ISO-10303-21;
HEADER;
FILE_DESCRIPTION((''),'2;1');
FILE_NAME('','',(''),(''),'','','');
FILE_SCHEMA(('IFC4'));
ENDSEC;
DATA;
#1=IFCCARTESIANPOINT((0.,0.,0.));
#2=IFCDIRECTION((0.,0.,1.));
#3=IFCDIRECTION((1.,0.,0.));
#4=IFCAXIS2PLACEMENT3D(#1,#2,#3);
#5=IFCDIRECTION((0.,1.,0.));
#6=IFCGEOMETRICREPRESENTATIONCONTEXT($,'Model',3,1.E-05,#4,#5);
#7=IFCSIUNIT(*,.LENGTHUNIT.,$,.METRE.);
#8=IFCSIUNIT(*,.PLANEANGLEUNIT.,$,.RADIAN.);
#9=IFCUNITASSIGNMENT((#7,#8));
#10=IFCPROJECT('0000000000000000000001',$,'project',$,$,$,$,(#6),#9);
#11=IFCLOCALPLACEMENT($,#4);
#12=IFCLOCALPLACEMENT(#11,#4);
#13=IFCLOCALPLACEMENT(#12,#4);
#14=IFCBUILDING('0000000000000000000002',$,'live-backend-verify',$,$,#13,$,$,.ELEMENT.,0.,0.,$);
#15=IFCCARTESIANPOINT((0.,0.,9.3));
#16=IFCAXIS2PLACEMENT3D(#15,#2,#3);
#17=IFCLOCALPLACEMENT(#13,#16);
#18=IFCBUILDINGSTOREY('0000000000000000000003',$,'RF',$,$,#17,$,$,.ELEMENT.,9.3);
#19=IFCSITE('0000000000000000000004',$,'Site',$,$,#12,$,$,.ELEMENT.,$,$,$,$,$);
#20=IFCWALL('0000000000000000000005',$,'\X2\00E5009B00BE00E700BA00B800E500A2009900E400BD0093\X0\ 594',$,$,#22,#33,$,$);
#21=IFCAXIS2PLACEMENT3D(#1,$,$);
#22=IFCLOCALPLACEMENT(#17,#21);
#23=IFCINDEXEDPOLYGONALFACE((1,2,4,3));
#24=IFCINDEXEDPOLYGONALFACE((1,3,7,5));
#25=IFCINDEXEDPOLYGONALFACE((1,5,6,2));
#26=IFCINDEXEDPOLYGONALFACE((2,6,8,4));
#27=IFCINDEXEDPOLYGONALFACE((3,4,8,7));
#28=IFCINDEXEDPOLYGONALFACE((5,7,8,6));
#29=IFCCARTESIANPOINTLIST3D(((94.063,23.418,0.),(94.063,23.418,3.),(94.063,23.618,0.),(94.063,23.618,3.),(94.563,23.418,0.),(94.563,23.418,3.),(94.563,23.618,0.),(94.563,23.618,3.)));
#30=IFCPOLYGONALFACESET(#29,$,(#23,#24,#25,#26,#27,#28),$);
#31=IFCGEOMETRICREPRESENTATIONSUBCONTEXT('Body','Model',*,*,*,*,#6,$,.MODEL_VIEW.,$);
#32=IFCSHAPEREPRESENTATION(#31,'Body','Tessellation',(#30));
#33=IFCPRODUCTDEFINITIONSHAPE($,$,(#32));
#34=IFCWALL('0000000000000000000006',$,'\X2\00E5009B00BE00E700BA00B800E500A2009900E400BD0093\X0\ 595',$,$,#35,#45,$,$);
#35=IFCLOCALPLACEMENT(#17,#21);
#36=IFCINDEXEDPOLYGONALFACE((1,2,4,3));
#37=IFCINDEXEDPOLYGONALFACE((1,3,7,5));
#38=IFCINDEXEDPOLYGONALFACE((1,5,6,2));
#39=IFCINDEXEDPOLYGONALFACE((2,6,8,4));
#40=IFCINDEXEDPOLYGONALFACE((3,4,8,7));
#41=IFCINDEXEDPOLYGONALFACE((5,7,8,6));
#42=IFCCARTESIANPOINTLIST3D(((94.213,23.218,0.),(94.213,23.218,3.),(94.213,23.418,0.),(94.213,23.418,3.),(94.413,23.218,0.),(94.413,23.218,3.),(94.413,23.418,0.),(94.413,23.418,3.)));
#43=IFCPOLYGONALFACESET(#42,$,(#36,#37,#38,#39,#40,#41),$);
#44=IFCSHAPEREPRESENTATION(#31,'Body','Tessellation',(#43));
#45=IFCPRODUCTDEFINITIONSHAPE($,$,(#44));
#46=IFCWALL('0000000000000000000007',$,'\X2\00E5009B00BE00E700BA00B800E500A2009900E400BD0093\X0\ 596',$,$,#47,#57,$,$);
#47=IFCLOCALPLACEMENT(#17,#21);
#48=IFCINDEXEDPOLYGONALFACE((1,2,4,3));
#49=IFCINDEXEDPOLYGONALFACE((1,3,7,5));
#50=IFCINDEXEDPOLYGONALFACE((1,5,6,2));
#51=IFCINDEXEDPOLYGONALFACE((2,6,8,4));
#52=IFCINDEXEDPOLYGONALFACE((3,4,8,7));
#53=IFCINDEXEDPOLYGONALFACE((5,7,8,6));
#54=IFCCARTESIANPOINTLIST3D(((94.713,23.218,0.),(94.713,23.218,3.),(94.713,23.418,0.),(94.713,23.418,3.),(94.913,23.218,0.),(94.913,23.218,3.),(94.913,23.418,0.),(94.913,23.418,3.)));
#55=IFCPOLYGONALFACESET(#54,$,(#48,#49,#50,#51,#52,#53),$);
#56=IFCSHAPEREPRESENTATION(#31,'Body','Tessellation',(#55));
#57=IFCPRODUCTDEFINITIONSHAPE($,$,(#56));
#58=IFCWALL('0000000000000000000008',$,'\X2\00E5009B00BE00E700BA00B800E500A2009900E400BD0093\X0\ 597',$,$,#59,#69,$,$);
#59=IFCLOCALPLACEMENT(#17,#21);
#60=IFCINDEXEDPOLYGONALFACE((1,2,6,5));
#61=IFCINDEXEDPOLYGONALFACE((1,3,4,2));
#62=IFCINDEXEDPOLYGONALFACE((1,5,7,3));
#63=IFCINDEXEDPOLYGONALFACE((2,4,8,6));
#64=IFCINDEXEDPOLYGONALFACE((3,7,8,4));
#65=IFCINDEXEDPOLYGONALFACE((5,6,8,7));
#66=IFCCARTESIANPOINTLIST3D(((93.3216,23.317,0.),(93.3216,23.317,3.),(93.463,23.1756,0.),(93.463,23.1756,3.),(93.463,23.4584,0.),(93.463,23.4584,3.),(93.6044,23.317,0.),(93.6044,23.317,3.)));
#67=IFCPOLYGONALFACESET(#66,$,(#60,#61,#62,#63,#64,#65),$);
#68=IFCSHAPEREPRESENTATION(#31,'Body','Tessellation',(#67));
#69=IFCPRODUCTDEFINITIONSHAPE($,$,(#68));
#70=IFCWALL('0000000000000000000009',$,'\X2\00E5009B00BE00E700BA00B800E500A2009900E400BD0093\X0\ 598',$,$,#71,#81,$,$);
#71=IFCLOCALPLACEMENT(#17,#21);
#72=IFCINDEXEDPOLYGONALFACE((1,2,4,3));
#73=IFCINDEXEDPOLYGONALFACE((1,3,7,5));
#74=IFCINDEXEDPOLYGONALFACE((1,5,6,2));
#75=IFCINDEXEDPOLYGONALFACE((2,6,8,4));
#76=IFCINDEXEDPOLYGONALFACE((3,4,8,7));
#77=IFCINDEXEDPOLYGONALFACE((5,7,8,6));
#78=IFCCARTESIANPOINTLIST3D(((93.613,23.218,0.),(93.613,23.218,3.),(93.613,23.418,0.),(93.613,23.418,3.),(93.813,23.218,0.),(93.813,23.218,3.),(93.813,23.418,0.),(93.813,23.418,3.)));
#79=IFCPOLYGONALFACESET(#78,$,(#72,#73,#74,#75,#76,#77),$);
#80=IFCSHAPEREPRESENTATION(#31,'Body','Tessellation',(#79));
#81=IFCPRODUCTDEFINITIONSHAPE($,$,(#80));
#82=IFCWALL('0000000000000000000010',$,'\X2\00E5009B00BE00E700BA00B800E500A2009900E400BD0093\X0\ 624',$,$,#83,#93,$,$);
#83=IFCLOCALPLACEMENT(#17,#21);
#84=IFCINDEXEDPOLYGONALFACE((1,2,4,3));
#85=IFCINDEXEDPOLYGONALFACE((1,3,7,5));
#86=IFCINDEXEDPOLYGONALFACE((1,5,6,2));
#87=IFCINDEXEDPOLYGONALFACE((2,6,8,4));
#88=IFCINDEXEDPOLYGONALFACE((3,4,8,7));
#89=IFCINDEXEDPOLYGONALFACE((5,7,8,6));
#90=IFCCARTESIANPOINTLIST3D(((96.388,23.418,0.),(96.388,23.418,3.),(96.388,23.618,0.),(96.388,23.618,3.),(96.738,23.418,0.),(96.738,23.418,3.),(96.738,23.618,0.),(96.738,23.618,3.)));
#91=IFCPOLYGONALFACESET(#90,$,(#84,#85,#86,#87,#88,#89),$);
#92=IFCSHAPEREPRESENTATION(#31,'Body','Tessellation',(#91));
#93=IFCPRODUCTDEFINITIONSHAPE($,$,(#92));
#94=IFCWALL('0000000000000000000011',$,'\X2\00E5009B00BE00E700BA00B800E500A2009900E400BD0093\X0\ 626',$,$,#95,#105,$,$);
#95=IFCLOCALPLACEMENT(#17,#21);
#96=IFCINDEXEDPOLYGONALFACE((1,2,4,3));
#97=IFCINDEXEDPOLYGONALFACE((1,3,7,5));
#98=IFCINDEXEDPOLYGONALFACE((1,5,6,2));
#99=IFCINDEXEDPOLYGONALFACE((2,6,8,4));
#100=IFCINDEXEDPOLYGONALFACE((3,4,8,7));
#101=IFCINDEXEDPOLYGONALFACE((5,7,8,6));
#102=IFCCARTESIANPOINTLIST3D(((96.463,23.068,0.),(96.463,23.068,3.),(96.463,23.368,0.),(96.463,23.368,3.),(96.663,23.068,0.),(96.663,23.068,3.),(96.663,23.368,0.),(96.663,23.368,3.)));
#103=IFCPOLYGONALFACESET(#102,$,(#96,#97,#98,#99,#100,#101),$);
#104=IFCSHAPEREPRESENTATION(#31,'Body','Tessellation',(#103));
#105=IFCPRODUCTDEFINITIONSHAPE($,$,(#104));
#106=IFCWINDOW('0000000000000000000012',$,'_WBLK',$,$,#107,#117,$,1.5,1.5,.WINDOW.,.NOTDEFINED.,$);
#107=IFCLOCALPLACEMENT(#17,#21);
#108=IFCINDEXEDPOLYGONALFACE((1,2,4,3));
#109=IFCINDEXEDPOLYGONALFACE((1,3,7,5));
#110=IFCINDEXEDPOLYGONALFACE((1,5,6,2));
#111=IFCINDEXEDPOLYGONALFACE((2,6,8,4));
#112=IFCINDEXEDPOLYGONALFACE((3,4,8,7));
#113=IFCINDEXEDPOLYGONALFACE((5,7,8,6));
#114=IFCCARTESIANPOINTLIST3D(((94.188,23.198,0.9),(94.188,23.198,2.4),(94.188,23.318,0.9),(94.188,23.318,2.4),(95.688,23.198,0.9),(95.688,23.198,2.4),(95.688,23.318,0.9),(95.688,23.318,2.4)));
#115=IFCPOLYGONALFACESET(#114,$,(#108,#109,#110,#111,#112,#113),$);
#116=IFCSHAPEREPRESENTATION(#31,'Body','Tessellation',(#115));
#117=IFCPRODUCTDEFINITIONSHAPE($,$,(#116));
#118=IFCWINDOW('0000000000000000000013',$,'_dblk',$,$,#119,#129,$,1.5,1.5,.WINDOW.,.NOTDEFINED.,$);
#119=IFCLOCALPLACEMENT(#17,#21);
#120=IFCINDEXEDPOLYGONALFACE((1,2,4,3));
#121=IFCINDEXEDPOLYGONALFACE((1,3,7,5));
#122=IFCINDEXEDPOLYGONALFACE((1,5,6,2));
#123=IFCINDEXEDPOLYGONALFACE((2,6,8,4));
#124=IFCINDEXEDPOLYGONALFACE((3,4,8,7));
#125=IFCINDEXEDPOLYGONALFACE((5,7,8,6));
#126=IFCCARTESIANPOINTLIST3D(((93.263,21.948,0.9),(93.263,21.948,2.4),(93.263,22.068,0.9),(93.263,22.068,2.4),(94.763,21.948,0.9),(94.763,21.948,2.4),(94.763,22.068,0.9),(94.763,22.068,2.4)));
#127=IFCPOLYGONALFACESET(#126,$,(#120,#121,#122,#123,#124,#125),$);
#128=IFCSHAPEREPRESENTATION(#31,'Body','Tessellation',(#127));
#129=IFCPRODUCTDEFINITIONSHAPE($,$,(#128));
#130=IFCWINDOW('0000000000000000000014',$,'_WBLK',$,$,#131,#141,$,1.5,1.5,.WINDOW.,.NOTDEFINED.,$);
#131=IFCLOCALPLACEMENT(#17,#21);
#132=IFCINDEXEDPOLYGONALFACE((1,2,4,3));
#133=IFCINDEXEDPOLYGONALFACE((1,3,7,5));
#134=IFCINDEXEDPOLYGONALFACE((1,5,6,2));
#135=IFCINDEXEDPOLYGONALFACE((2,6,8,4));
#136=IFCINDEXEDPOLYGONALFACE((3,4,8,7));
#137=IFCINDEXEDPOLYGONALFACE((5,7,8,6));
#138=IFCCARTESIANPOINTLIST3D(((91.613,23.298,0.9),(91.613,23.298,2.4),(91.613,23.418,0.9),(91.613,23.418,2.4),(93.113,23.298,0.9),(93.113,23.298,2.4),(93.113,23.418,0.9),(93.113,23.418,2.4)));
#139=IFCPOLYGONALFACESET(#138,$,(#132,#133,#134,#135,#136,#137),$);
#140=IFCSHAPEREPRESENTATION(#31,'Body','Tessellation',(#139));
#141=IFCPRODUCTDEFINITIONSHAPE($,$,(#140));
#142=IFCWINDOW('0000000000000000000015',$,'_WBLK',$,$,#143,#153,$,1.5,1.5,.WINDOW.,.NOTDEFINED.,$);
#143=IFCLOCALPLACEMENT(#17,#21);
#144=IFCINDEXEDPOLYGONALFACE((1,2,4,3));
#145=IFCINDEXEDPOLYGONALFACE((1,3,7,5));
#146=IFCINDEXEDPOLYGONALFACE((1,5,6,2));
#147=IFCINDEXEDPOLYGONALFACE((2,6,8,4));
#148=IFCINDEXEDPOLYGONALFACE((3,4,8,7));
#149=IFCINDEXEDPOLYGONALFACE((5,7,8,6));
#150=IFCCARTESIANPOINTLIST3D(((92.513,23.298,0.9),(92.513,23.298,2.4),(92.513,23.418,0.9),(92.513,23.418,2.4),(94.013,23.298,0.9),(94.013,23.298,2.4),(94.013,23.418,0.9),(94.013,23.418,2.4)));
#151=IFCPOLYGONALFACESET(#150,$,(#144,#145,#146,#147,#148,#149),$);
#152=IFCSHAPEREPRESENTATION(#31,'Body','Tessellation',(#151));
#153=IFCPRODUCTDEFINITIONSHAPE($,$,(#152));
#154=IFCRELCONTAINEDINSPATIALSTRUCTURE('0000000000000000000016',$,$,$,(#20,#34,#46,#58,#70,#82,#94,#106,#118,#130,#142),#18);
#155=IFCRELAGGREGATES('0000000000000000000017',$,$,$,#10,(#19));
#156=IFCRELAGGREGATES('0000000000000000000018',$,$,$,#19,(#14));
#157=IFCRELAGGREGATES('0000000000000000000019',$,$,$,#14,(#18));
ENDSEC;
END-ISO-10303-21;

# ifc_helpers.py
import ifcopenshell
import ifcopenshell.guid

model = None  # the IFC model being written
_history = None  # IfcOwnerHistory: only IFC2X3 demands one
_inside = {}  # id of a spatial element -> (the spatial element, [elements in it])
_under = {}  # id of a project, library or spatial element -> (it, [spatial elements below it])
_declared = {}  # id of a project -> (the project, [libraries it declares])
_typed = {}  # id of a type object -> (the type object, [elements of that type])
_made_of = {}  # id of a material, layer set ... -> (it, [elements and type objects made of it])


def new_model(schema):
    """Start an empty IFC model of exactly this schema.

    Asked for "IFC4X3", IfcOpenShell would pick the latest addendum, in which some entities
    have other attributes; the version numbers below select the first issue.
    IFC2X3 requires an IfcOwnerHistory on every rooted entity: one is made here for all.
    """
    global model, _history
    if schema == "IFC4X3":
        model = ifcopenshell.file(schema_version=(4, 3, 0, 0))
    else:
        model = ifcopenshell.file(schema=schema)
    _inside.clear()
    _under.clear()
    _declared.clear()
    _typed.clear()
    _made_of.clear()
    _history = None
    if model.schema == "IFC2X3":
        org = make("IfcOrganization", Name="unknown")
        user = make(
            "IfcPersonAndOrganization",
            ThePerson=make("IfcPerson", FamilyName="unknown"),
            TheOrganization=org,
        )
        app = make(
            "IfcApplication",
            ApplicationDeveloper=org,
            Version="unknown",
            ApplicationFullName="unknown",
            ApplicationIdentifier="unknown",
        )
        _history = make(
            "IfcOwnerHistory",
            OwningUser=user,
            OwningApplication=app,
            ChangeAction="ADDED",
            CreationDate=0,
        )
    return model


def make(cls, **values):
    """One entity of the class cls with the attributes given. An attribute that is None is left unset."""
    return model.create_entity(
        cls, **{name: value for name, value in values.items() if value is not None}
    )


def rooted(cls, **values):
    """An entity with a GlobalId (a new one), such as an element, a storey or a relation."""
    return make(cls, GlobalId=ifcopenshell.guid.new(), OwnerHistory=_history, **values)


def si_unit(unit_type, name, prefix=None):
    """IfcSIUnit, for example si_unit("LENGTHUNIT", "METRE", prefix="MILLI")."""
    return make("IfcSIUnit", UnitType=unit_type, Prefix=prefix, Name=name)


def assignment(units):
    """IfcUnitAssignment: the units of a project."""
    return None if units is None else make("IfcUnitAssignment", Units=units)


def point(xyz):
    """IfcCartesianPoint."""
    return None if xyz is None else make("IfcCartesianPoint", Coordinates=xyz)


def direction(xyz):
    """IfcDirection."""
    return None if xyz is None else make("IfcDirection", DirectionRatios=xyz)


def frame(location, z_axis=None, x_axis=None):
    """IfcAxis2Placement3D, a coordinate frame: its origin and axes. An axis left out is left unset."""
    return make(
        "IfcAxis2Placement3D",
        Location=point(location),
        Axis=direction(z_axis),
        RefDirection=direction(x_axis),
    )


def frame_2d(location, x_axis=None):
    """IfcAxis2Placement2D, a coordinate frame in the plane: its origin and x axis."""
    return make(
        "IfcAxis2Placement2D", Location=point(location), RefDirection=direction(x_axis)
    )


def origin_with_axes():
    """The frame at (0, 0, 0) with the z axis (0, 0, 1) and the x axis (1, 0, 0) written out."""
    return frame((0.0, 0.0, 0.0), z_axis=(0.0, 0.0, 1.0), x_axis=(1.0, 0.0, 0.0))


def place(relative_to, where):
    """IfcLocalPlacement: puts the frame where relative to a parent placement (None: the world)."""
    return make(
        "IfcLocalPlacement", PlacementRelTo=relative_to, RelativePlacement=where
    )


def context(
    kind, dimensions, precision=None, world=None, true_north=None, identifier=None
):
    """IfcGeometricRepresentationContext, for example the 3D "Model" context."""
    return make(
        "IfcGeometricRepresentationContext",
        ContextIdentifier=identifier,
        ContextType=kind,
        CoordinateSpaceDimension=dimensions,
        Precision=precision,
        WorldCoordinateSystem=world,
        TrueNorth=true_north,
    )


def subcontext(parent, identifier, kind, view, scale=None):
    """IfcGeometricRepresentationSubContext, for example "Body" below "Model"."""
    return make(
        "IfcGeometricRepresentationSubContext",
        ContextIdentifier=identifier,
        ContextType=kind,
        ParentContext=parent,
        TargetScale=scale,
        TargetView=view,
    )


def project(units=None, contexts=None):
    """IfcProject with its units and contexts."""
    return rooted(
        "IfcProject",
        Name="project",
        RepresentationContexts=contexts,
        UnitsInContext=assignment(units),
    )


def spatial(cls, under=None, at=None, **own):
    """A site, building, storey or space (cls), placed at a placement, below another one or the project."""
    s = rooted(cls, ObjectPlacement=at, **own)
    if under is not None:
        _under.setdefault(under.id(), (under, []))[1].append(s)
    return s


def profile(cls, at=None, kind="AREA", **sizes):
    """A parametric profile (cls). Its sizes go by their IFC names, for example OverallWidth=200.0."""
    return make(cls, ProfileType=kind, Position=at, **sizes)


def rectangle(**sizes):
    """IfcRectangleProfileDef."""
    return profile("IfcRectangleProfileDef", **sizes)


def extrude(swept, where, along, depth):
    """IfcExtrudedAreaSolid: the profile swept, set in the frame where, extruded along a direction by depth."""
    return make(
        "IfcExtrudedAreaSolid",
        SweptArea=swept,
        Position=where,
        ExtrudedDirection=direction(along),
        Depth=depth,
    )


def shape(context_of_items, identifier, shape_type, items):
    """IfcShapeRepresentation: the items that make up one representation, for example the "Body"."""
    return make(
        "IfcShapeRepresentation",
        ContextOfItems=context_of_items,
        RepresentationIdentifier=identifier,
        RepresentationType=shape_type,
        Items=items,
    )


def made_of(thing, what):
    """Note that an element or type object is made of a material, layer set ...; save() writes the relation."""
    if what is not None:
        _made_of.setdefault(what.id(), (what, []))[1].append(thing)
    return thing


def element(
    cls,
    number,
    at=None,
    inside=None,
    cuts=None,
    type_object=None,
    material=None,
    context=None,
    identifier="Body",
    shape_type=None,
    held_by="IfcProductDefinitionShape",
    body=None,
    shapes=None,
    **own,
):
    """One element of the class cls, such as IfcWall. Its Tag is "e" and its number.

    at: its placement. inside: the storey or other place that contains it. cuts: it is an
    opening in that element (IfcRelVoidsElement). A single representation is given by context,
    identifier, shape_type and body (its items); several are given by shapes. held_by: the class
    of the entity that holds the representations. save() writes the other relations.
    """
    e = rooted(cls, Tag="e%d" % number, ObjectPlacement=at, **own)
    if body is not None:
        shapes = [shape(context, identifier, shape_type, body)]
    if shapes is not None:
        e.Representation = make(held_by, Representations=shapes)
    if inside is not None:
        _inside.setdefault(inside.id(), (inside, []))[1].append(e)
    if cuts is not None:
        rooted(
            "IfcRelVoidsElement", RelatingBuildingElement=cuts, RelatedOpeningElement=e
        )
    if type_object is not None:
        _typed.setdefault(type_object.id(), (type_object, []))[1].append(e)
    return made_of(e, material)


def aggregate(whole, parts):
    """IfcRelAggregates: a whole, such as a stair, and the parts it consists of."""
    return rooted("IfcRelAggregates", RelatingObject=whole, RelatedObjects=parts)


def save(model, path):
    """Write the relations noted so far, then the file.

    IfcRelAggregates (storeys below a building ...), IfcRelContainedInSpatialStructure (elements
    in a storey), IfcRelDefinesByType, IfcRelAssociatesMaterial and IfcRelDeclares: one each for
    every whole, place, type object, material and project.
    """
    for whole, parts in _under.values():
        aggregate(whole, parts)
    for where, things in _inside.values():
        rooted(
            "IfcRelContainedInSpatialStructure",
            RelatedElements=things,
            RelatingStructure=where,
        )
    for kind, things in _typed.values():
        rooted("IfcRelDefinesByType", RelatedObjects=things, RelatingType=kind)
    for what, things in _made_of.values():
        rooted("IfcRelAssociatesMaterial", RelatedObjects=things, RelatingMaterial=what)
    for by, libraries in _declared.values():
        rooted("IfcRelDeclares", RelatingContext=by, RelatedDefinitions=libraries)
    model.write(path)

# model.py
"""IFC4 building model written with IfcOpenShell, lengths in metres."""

from ifc_helpers import new_model, si_unit, direction, frame, frame_2d, origin_with_axes, place, context, subcontext, project, spatial, rectangle, extrude, element, save


model = new_model("IFC4")

# Units and contexts
model_context = context("Model", 3, precision=1e-05, world=origin_with_axes(), true_north=direction((0.0, 1.0, 0.0)))
body_context = subcontext(model_context, "Body", "Model", "MODEL_VIEW")
ifc_project = project(units=[si_unit("LENGTHUNIT", "METRE"), si_unit("PLANEANGLEUNIT", "RADIAN")], contexts=[model_context])

# Site, building, storey
placement = place(None, origin_with_axes())
site_placement = place(placement, origin_with_axes())
site = spatial("IfcSite", under=ifc_project, at=site_placement, Name="Site", CompositionType="ELEMENT")
building_placement = place(site_placement, origin_with_axes())
building = spatial("IfcBuilding", under=site, at=building_placement, Name="live-backend-verify", CompositionType="ELEMENT", ElevationOfRefHeight=0.0, ElevationOfTerrain=0.0)
storey_placement = place(building_placement, frame((0.0, 0.0, 9.3), z_axis=(0.0, 0.0, 1.0), x_axis=(1.0, 0.0, 0.0)))
storey = spatial("IfcBuildingStorey", under=building, at=storey_placement, Name="RF", CompositionType="ELEMENT", Elevation=9.3)

# Walls
wall_1_placement = place(storey_placement, frame((94.313, 23.518, 0.0), z_axis=(0.0, 0.0, 1.0), x_axis=(1.0, 0.0, 0.0)))
element("IfcWall", 1, at=wall_1_placement, inside=storey, Name="å\u009b¾çº¸å¢\u0099ä½\u0093 594", context=body_context, shape_type="SweptSolid", body=[
    extrude(rectangle(XDim=0.5, YDim=0.2, at=frame_2d((0.0, 0.0), x_axis=(1.0, 0.0, 0.0))), frame((0.0, 0.0, 0.0), z_axis=(0.0, 0.0, 1.0)), (0.0, 0.0, 1.0), 3.0),
])
for number, where, z_axis, x_axis, name in (
    (2, (94.313, 23.318, 0.0), (0.0, 0.0, 1.0), (0.0, 1.0, 0.0), "å\u009b¾çº¸å¢\u0099ä½\u0093 595"),
    (3, (94.813, 23.318, 0.0), (0.0, 0.0, 1.0), (0.0, 1.0, 0.0), "å\u009b¾çº¸å¢\u0099ä½\u0093 596"),
    (4, (93.463, 23.317, 0.0), (0.0, 0.0, 1.0), (-0.707107, 0.707107, 0.0), "å\u009b¾çº¸å¢\u0099ä½\u0093 597"),
    (5, (93.713, 23.318, 0.0), (0.0, 0.0, 1.0), (-1.0, 0.0, 0.0), "å\u009b¾çº¸å¢\u0099ä½\u0093 598"),
):
    element("IfcWall", number, at=place(storey_placement, frame(where, z_axis=z_axis, x_axis=x_axis)), inside=storey, Name=name, context=body_context, shape_type="SweptSolid", body=[
        extrude(rectangle(XDim=0.2, YDim=0.2, at=frame_2d((0.0, 0.0), x_axis=(1.0, 0.0, 0.0))), frame((0.0, 0.0, 0.0), z_axis=(0.0, 0.0, 1.0)), (0.0, 0.0, 1.0), 3.0),
    ])
wall_2_placement = place(storey_placement, frame((96.563, 23.518, 0.0), z_axis=(0.0, 0.0, 1.0), x_axis=(1.0, 0.0, 0.0)))
element("IfcWall", 6, at=wall_2_placement, inside=storey, Name="å\u009b¾çº¸å¢\u0099ä½\u0093 624", context=body_context, shape_type="SweptSolid", body=[
    extrude(rectangle(XDim=0.35, YDim=0.2, at=frame_2d((0.0, 0.0), x_axis=(1.0, 0.0, 0.0))), frame((0.0, 0.0, 0.0), z_axis=(0.0, 0.0, 1.0)), (0.0, 0.0, 1.0), 3.0),
])
wall_3_placement = place(storey_placement, frame((96.563, 23.218, 0.0), z_axis=(0.0, 0.0, 1.0), x_axis=(0.0, 1.0, 0.0)))
element("IfcWall", 7, at=wall_3_placement, inside=storey, Name="å\u009b¾çº¸å¢\u0099ä½\u0093 626", context=body_context, shape_type="SweptSolid", body=[
    extrude(rectangle(XDim=0.3, YDim=0.2, at=frame_2d((0.0, 0.0), x_axis=(1.0, 0.0, 0.0))), frame((0.0, 0.0, 0.0), z_axis=(0.0, 0.0, 1.0)), (0.0, 0.0, 1.0), 3.0),
])

# Windows
for number, where, z_axis, x_axis, name in (
    (8, (94.938, 23.258, 0.9), (0.0, 0.0, 1.0), (1.0, 0.0, 0.0), "_WBLK"),
    (9, (94.013, 22.008, 0.9), (0.0, 0.0, 1.0), (1.0, 0.0, 0.0), "_dblk"),
    (10, (92.363, 23.358, 0.9), (0.0, 0.0, 1.0), (1.0, 0.0, 0.0), "_WBLK"),
    (11, (93.263, 23.358, 0.9), (0.0, 0.0, 1.0), (1.0, 0.0, 0.0), "_WBLK"),
):
    element("IfcWindow", number, at=place(storey_placement, frame(where, z_axis=z_axis, x_axis=x_axis)), inside=storey, Name=name, OverallHeight=1.5, OverallWidth=1.5, PartitioningType="NOTDEFINED", PredefinedType="WINDOW", context=body_context, shape_type="SweptSolid", body=[
        extrude(rectangle(XDim=1.5, YDim=0.12, at=frame_2d((0.0, 0.0), x_axis=(1.0, 0.0, 0.0))), frame((0.0, 0.0, 0.0), z_axis=(0.0, 0.0, 1.0)), (0.0, 0.0, 1.0), 1.5),
    ])

save(model, "model.ifc")
